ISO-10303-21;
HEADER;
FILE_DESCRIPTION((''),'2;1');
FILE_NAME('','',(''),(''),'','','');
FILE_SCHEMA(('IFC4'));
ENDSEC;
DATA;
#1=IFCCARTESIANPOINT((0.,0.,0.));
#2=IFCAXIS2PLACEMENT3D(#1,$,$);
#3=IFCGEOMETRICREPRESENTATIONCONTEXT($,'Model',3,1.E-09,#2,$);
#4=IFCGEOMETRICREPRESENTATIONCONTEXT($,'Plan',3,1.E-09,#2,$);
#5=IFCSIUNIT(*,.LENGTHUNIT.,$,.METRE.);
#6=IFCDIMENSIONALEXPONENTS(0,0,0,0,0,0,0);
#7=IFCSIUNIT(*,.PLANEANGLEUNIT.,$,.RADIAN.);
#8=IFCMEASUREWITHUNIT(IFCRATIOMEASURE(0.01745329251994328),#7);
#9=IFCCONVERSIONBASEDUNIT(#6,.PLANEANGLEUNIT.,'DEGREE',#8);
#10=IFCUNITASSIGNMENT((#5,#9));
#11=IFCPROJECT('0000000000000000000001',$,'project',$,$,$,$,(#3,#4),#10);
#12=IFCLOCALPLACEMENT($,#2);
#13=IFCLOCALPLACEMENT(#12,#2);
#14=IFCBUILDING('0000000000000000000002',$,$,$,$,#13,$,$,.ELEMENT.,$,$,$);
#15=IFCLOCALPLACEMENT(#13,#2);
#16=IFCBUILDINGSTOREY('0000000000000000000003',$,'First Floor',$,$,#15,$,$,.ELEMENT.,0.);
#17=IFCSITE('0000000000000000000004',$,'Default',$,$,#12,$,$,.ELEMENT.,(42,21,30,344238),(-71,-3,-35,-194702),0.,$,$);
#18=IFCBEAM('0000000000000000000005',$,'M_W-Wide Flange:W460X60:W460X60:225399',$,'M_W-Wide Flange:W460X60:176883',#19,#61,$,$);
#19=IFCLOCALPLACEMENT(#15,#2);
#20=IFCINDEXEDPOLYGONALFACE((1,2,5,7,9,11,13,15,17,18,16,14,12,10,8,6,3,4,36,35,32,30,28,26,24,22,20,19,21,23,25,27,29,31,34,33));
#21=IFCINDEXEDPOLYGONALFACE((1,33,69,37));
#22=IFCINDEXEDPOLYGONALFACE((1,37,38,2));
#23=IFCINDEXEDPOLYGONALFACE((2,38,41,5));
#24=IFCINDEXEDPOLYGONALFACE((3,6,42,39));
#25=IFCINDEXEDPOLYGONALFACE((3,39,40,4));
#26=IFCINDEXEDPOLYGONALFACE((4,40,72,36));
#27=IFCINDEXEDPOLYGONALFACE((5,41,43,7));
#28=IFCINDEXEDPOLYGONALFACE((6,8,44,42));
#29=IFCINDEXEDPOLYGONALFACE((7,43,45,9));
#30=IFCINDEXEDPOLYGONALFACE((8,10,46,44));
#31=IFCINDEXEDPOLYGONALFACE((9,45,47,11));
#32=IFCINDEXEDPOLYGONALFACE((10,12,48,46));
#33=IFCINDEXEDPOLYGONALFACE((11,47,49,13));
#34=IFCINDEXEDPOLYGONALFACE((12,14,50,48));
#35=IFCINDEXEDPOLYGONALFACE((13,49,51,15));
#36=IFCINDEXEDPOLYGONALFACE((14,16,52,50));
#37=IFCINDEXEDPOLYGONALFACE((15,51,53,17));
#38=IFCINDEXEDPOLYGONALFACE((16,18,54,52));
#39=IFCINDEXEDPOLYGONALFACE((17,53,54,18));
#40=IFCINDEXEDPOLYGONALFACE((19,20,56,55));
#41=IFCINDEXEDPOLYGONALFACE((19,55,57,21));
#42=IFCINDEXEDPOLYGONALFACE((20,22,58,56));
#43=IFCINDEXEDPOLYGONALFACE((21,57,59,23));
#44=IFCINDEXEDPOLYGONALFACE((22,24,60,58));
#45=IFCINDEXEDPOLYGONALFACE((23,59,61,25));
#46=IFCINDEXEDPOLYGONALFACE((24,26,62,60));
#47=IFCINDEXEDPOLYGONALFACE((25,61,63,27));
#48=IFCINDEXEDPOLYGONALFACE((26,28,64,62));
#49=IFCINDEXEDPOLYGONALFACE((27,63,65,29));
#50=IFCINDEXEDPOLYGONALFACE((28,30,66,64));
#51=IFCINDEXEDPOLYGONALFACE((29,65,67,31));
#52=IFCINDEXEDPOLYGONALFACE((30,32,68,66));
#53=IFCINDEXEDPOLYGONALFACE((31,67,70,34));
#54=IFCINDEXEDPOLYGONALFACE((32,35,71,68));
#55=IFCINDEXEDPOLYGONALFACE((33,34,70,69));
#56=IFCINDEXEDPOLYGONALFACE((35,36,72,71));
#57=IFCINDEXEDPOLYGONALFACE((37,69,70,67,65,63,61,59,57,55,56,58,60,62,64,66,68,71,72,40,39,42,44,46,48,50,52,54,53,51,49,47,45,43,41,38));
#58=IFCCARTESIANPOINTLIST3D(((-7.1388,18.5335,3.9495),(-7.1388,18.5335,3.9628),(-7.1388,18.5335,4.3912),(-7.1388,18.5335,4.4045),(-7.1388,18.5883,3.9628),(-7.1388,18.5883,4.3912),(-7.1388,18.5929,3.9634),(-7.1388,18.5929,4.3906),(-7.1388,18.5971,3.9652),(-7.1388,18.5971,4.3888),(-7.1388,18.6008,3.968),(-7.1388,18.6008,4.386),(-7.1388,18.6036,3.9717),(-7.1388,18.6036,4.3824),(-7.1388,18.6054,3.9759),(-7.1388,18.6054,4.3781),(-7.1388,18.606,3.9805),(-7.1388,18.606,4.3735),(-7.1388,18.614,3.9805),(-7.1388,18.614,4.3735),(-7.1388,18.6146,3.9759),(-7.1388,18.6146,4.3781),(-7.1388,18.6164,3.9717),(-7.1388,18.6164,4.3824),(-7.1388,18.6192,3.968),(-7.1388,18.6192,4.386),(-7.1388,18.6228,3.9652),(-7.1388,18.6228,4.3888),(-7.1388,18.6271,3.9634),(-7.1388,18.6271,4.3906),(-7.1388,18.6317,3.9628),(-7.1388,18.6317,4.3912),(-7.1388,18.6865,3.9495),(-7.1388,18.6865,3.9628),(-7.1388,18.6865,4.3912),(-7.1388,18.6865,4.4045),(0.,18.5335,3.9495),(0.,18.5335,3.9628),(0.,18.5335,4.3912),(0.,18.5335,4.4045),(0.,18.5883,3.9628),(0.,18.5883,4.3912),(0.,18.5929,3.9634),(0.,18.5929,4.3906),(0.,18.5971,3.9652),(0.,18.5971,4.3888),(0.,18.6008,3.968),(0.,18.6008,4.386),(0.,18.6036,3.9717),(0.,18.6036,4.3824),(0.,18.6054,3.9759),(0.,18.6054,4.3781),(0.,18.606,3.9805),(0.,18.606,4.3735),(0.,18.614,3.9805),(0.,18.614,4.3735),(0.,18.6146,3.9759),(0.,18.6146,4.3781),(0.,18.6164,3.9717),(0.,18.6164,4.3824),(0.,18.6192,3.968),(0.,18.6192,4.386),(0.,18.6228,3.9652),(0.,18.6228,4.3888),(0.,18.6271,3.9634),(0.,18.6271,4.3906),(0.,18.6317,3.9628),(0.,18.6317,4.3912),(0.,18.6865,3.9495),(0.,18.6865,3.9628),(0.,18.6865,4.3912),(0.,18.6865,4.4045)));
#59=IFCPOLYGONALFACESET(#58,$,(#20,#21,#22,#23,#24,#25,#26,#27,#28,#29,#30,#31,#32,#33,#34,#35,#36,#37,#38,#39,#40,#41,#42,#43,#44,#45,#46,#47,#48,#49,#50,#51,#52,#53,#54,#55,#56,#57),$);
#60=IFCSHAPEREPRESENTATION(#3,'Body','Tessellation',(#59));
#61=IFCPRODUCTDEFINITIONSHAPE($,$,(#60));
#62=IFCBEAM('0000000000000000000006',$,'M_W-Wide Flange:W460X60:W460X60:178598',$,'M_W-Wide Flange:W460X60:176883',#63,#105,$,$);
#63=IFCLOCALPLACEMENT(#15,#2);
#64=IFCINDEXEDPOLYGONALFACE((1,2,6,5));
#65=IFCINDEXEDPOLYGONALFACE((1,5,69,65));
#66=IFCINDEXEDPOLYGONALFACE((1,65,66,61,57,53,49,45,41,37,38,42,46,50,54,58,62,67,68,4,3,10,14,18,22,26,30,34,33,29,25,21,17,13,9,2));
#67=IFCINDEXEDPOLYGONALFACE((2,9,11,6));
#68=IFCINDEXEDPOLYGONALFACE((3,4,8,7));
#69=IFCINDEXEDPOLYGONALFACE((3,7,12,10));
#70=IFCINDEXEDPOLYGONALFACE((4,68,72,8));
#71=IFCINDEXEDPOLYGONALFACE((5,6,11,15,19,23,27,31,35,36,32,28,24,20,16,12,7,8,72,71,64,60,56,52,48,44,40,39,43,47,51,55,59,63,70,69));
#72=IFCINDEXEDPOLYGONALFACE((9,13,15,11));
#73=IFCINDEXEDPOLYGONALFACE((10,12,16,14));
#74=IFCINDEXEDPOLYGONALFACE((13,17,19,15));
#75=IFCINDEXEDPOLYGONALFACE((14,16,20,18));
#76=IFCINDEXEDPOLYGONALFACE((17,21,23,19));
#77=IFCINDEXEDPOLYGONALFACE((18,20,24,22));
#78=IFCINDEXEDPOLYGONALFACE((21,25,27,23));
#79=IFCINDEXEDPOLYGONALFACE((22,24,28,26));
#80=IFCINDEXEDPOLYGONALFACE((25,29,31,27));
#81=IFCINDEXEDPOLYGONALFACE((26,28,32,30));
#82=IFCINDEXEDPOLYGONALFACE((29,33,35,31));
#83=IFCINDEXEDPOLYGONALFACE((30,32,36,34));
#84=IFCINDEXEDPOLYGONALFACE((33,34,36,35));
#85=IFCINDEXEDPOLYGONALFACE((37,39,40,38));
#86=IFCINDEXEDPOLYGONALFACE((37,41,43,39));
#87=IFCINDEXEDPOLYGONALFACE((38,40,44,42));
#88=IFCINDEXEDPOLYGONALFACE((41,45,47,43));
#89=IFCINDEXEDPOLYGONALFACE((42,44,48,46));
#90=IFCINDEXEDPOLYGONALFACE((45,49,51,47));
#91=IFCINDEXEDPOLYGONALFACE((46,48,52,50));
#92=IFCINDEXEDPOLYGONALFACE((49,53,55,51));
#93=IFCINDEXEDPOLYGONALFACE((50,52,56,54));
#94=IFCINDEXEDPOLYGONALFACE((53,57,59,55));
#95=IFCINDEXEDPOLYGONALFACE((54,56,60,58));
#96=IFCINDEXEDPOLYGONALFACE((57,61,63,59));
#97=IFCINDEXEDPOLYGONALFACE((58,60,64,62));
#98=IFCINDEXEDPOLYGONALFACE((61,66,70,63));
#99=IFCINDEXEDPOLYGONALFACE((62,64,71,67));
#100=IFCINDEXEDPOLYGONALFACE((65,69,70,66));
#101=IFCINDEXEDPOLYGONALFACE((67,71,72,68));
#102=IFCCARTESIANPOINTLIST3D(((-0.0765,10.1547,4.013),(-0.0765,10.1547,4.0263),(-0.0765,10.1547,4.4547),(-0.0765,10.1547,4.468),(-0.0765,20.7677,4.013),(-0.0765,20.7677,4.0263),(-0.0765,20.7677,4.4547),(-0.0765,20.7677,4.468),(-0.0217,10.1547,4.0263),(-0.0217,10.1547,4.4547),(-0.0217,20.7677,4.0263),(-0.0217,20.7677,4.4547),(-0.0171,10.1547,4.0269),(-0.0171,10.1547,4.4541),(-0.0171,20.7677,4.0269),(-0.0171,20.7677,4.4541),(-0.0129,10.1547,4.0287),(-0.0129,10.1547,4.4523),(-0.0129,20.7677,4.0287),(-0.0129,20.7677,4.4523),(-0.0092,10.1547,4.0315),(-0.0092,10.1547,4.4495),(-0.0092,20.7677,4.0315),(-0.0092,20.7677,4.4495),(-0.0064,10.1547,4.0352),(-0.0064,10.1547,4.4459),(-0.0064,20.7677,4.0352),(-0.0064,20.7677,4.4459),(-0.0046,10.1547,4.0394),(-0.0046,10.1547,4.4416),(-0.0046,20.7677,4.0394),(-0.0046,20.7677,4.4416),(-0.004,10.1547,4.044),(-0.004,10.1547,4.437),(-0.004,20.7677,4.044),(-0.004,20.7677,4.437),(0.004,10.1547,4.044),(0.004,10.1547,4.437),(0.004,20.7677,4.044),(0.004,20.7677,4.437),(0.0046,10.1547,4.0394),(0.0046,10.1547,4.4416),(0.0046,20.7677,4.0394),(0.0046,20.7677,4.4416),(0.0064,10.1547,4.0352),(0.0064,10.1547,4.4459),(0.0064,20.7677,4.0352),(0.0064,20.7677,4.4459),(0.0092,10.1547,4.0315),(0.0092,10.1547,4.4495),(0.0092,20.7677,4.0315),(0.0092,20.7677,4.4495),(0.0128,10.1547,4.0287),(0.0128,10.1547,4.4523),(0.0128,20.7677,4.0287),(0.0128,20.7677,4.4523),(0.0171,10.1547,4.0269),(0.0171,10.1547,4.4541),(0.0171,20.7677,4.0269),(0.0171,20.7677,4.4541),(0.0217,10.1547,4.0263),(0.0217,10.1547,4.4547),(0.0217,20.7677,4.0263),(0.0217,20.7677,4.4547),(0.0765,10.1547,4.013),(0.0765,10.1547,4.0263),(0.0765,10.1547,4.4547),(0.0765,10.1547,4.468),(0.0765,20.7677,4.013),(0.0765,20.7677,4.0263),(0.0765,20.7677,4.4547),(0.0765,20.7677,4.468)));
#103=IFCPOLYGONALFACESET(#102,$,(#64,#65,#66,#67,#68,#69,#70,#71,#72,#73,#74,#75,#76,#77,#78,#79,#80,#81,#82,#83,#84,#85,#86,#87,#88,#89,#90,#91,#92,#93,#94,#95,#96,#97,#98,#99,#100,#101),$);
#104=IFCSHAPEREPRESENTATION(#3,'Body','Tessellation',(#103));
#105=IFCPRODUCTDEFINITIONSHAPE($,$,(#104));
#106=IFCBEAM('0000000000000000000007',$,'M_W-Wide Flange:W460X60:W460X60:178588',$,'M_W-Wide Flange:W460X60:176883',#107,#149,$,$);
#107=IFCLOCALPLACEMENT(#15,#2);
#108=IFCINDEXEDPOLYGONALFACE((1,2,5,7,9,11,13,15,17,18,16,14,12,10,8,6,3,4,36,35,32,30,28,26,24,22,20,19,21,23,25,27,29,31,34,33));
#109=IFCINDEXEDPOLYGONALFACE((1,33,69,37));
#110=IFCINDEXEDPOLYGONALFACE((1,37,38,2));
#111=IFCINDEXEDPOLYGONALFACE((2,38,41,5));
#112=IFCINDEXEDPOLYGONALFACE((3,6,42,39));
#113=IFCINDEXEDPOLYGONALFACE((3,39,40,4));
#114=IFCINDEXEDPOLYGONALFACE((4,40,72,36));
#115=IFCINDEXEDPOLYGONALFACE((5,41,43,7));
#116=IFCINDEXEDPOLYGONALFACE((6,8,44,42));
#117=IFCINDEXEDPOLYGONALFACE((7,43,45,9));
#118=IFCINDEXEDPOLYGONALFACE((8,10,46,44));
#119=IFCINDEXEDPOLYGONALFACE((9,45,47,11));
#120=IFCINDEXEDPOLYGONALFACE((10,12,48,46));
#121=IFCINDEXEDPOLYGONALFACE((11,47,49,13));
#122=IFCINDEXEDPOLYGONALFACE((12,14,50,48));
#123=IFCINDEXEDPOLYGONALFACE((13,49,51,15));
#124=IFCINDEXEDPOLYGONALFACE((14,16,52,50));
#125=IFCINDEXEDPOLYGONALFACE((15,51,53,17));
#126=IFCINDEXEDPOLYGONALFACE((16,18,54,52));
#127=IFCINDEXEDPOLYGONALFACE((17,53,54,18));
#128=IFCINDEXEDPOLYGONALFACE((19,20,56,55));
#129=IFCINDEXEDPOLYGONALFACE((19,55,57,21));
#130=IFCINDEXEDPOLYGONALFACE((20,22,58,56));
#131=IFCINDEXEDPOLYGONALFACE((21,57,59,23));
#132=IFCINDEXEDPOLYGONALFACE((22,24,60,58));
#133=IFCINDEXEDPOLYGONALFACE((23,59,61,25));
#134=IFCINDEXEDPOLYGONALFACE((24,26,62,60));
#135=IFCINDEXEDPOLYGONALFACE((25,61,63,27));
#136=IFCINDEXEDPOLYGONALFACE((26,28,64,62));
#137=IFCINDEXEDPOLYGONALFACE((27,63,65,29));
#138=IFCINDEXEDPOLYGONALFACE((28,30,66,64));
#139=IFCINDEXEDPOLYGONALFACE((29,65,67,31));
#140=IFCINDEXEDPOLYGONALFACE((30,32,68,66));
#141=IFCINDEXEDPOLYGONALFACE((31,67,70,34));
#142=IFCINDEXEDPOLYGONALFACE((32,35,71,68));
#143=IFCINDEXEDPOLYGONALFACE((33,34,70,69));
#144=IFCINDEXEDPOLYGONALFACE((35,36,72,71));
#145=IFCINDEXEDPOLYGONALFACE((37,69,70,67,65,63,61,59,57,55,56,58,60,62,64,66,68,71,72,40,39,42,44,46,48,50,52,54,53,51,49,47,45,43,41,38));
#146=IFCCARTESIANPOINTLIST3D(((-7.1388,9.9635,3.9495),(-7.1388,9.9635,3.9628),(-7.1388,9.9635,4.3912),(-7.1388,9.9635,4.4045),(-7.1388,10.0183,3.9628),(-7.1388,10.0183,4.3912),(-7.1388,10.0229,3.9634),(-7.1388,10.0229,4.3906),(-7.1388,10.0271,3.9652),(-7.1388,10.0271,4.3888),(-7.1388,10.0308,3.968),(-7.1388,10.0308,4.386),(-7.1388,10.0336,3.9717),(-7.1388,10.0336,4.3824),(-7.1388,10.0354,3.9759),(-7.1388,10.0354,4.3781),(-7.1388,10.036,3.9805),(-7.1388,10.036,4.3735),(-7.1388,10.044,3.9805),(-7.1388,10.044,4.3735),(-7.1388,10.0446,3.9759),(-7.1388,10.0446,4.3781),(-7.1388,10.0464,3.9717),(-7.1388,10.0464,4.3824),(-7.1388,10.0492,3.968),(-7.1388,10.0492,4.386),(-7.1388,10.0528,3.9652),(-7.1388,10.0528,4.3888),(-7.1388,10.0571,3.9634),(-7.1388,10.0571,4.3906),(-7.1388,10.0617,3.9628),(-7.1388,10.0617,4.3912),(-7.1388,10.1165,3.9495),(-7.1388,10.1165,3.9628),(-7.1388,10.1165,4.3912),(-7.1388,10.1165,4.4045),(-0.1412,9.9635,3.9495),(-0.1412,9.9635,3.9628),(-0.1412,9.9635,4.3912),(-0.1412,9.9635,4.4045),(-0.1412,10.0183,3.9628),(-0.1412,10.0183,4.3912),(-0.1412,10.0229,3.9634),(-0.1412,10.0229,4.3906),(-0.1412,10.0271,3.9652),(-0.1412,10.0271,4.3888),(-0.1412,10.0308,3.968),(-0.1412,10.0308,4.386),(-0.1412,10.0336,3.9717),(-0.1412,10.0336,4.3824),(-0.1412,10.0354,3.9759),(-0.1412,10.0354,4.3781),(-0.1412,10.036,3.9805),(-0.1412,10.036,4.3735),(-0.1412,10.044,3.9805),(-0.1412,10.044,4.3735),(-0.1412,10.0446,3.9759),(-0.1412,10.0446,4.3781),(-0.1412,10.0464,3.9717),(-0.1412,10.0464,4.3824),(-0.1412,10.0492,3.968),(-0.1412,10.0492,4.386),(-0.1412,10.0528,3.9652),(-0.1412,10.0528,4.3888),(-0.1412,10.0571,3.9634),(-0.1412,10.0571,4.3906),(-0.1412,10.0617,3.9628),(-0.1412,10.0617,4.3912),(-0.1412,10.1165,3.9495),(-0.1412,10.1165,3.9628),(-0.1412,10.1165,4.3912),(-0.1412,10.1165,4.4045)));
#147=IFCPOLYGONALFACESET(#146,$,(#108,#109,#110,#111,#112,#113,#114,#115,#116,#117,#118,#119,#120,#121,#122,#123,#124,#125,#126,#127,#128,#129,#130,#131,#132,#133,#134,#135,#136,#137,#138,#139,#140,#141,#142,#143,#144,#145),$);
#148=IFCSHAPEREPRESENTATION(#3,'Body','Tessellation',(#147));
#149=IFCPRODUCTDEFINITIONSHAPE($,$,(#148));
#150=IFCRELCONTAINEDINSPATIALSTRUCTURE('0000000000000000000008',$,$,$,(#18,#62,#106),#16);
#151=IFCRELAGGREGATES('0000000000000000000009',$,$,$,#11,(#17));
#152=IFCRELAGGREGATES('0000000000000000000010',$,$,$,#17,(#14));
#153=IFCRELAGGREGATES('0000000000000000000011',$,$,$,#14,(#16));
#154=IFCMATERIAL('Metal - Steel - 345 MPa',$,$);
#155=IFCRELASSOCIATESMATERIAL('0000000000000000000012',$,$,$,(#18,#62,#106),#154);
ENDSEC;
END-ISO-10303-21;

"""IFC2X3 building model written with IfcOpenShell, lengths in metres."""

from ifc_helpers import new_model, entity, si_unit, converted_unit, frame, frame_2d, origin, place, context, project, spatial, polyline, circle_curve, parameter, trimmed, segment, composite_curve, outline, extrude, material, element, save


model = new_model("IFC2X3")

# Units and contexts
model_context = context("Model", 3, precision=1e-09, world=origin())
plan_context = context("Plan", 3, precision=1e-09, world=origin())
ifc_project = project(units=[si_unit("LENGTHUNIT", "METRE"), converted_unit("PLANEANGLEUNIT", "DEGREE", entity("IfcRatioMeasure", 0.01745329251994328), si_unit("PLANEANGLEUNIT", "RADIAN"), dimensions=[0, 0, 0, 0, 0, 0, 0])], contexts=[model_context, plan_context])

# Site, building, storey
site_placement = place(None, origin())
site = spatial("IfcSite", under=ifc_project, at=site_placement, Name="Default", CompositionType="ELEMENT", RefLatitude=(42, 21, 30, 344238), RefLongitude=(-71, -3, -35, -194702), RefElevation=0.0)
building_placement = place(site_placement, origin())
building = spatial("IfcBuilding", under=site, at=building_placement, CompositionType="ELEMENT")
storey_placement = place(building_placement, origin())
storey = spatial("IfcBuildingStorey", under=building, at=storey_placement, Name="First Floor", CompositionType="ELEMENT", Elevation=0.0)

# Shared definitions
ifc_material = material(Name="Metal - Steel - 345 MPa")

# Beams
beam_1_placement = place(storey_placement, frame((-7.6018, 18.61, 4.4045), z_axis=(0.0, 0.0, 1.0), x_axis=(0.0, -1.0, 0.0)))
element("IfcBeam", 1, at=beam_1_placement, inside=storey, material=ifc_material, Name="M_W-Wide Flange:W460X60:W460X60:225399", ObjectType="M_W-Wide Flange:W460X60:176883", context=model_context, shape_type="SweptSolid", body=[
    extrude(outline(composite_curve([segment(polyline([(-0.0765, -0.2142), (-0.0765, -0.2275)]), True, "CONTINUOUS"), segment(polyline([(-0.0765, -0.2275), (0.0765, -0.2275)]), True, "CONTINUOUS"), segment(polyline([(0.0765, -0.2275), (0.0765, -0.2142)]), True, "CONTINUOUS"), segment(polyline([(0.0765, -0.2142), (0.0217, -0.2142)]), True, "CONTINUOUS"), segment(trimmed(circle_curve(frame_2d((0.0217, -0.1965), x_axis=(1.0, 0.0)), 0.0177), [parameter(180.0)], [parameter(270.0)], True, "PARAMETER"), False, "CONTINUOUS"), segment(polyline([(0.004, -0.1965), (0.004, 0.1965)]), True, "CONTINUOUS"), segment(trimmed(circle_curve(frame_2d((0.0217, 0.1965), x_axis=(1.0, 0.0)), 0.0177), [parameter(90.0)], [parameter(180.0)], True, "PARAMETER"), False, "CONTINUOUS"), segment(polyline([(0.0217, 0.2142), (0.0765, 0.2142)]), True, "CONTINUOUS"), segment(polyline([(0.0765, 0.2142), (0.0765, 0.2275)]), True, "CONTINUOUS"), segment(polyline([(0.0765, 0.2275), (-0.0765, 0.2275)]), True, "CONTINUOUS"), segment(polyline([(-0.0765, 0.2275), (-0.0765, 0.2142)]), True, "CONTINUOUS"), segment(polyline([(-0.0765, 0.2142), (-0.0217, 0.2142)]), True, "CONTINUOUS"), segment(trimmed(circle_curve(frame_2d((-0.0217, 0.1965), x_axis=(1.0, 0.0)), 0.0177), [parameter(360.0)], [parameter(90.0)], True, "PARAMETER"), False, "CONTINUOUS"), segment(polyline([(-0.004, 0.1965), (-0.004, -0.1965)]), True, "CONTINUOUS"), segment(trimmed(circle_curve(frame_2d((-0.0217, -0.1965), x_axis=(1.0, 0.0)), 0.0177), [parameter(270.0)], [parameter(0.0)], True, "PARAMETER"), False, "CONTINUOUS"), segment(polyline([(-0.0217, -0.2142), (-0.0765, -0.2142)]), True, "CONTINUOUS")], self_intersect=False)), frame((0.0, 0.463, -0.2275), z_axis=(0.0, -1.0, 0.0), x_axis=(1.0, 0.0, 0.0)), (0.0, 0.0, -1.0), 7.1388),
])
beam_2_placement = place(storey_placement, frame((0.0, 10.0387, 4.468)))
element("IfcBeam", 2, at=beam_2_placement, inside=storey, material=ifc_material, Name="M_W-Wide Flange:W460X60:W460X60:178598", ObjectType="M_W-Wide Flange:W460X60:176883", context=model_context, shape_type="SweptSolid", body=[
    extrude(outline(composite_curve([segment(polyline([(-0.0765, -0.2142), (-0.0765, -0.2275)]), True, "CONTINUOUS"), segment(polyline([(-0.0765, -0.2275), (0.0765, -0.2275)]), True, "CONTINUOUS"), segment(polyline([(0.0765, -0.2275), (0.0765, -0.2142)]), True, "CONTINUOUS"), segment(polyline([(0.0765, -0.2142), (0.0217, -0.2142)]), True, "CONTINUOUS"), segment(trimmed(circle_curve(frame_2d((0.0217, -0.1965), x_axis=(1.0, 0.0)), 0.0177), [parameter(180.0)], [parameter(270.0)], True, "PARAMETER"), False, "CONTINUOUS"), segment(polyline([(0.004, -0.1965), (0.004, 0.1965)]), True, "CONTINUOUS"), segment(trimmed(circle_curve(frame_2d((0.0217, 0.1965), x_axis=(1.0, 0.0)), 0.0177), [parameter(90.0)], [parameter(180.0)], True, "PARAMETER"), False, "CONTINUOUS"), segment(polyline([(0.0217, 0.2142), (0.0765, 0.2142)]), True, "CONTINUOUS"), segment(polyline([(0.0765, 0.2142), (0.0765, 0.2275)]), True, "CONTINUOUS"), segment(polyline([(0.0765, 0.2275), (-0.0765, 0.2275)]), True, "CONTINUOUS"), segment(polyline([(-0.0765, 0.2275), (-0.0765, 0.2142)]), True, "CONTINUOUS"), segment(polyline([(-0.0765, 0.2142), (-0.0217, 0.2142)]), True, "CONTINUOUS"), segment(trimmed(circle_curve(frame_2d((-0.0217, 0.1965), x_axis=(1.0, 0.0)), 0.0177), [parameter(360.0)], [parameter(90.0)], True, "PARAMETER"), False, "CONTINUOUS"), segment(polyline([(-0.004, 0.1965), (-0.004, -0.1965)]), True, "CONTINUOUS"), segment(trimmed(circle_curve(frame_2d((-0.0217, -0.1965), x_axis=(1.0, 0.0)), 0.0177), [parameter(270.0)], [parameter(0.0)], True, "PARAMETER"), False, "CONTINUOUS"), segment(polyline([(-0.0217, -0.2142), (-0.0765, -0.2142)]), True, "CONTINUOUS")], self_intersect=False)), frame((0.0, 0.116, -0.2275), z_axis=(0.0, -1.0, 0.0), x_axis=(1.0, 0.0, 0.0)), (0.0, 0.0, -1.0), 10.613),
])
beam_3_placement = place(storey_placement, frame((-7.2819, 10.04, 4.4045), z_axis=(0.0, 0.0, 1.0), x_axis=(0.0, -1.0, 0.0)))
element("IfcBeam", 3, at=beam_3_placement, inside=storey, material=ifc_material, Name="M_W-Wide Flange:W460X60:W460X60:178588", ObjectType="M_W-Wide Flange:W460X60:176883", context=model_context, shape_type="SweptSolid", body=[
    extrude(outline(composite_curve([segment(polyline([(-0.0765, -0.2142), (-0.0765, -0.2275)]), True, "CONTINUOUS"), segment(polyline([(-0.0765, -0.2275), (0.0765, -0.2275)]), True, "CONTINUOUS"), segment(polyline([(0.0765, -0.2275), (0.0765, -0.2142)]), True, "CONTINUOUS"), segment(polyline([(0.0765, -0.2142), (0.0217, -0.2142)]), True, "CONTINUOUS"), segment(trimmed(circle_curve(frame_2d((0.0217, -0.1965), x_axis=(0.0, -1.0)), 0.0177), [parameter(270.0)], [parameter(360.0)], True, "PARAMETER"), False, "CONTINUOUS"), segment(polyline([(0.004, -0.1965), (0.004, 0.1965)]), True, "CONTINUOUS"), segment(trimmed(circle_curve(frame_2d((0.0217, 0.1965), x_axis=(-1.0, 0.0)), 0.0177), [parameter(270.0)], [parameter(360.0)], True, "PARAMETER"), False, "CONTINUOUS"), segment(polyline([(0.0217, 0.2142), (0.0765, 0.2142)]), True, "CONTINUOUS"), segment(polyline([(0.0765, 0.2142), (0.0765, 0.2275)]), True, "CONTINUOUS"), segment(polyline([(0.0765, 0.2275), (-0.0765, 0.2275)]), True, "CONTINUOUS"), segment(polyline([(-0.0765, 0.2275), (-0.0765, 0.2142)]), True, "CONTINUOUS"), segment(polyline([(-0.0765, 0.2142), (-0.0217, 0.2142)]), True, "CONTINUOUS"), segment(trimmed(circle_curve(frame_2d((-0.0217, 0.1965), x_axis=(0.0, 1.0)), 0.0177), [parameter(270.0)], [parameter(360.0)], True, "PARAMETER"), False, "CONTINUOUS"), segment(polyline([(-0.004, 0.1965), (-0.004, -0.1965)]), True, "CONTINUOUS"), segment(trimmed(circle_curve(frame_2d((-0.0217, -0.1965), x_axis=(1.0, 0.0)), 0.0177), [parameter(270.0)], [parameter(0.0)], True, "PARAMETER"), False, "CONTINUOUS"), segment(polyline([(-0.0217, -0.2142), (-0.0765, -0.2142)]), True, "CONTINUOUS")], self_intersect=False)), frame((0.0, 0.1431, -0.2275), z_axis=(0.0, -1.0, 0.0), x_axis=(1.0, 0.0, 0.0)), (0.0, 0.0, -1.0), 6.9976),
])

save(model, "model.ifc")
